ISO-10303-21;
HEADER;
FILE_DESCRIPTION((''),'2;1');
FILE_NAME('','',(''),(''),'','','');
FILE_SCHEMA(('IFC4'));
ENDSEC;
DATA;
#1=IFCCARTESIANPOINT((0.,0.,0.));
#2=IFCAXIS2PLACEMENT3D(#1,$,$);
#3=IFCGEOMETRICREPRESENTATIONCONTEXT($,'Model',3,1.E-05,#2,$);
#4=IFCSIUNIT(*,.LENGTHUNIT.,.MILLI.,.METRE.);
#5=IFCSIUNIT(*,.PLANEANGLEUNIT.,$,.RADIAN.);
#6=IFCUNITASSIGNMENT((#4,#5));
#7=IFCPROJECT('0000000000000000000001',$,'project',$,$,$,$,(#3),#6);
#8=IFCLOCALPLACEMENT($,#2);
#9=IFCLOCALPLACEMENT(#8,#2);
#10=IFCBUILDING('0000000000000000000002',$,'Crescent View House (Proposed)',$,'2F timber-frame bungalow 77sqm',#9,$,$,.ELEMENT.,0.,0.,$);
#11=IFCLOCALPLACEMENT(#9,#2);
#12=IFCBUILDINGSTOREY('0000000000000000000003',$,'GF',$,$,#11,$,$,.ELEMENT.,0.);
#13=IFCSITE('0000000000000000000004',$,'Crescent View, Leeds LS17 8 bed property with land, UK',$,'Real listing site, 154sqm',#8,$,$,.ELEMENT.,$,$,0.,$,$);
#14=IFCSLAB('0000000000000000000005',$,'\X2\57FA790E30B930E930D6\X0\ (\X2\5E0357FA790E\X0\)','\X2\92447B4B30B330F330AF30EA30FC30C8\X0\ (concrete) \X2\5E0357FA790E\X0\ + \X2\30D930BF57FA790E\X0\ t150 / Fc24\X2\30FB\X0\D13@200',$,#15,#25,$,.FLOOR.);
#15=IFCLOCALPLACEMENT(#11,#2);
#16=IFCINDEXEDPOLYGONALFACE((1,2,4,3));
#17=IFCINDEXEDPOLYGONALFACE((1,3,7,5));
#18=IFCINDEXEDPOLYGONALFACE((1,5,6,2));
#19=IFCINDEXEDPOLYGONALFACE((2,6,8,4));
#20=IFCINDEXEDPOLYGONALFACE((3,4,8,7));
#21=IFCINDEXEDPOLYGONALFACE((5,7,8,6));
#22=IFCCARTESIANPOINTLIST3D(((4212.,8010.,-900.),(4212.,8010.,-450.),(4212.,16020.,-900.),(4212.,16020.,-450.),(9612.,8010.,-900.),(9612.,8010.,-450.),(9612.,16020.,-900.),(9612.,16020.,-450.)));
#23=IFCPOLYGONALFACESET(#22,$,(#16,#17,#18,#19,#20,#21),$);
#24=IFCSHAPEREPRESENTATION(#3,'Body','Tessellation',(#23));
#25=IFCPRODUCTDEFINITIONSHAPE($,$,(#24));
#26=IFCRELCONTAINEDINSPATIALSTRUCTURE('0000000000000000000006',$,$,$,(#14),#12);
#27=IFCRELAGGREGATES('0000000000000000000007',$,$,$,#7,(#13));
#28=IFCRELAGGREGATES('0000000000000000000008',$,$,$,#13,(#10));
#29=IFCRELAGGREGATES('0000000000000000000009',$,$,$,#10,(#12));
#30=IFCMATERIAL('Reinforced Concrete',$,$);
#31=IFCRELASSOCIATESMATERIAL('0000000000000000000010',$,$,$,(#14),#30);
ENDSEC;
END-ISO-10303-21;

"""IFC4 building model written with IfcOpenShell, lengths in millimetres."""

from ifc_helpers import new_model, si_unit, frame, frame_2d, origin, place, context, project, spatial, rectangle, extrude, material, element, save


model = new_model("IFC4")

# Units and contexts
model_context = context("Model", 3, precision=1e-05, world=origin())
ifc_project = project(units=[si_unit("LENGTHUNIT", "METRE", prefix="MILLI"), si_unit("PLANEANGLEUNIT", "RADIAN")], contexts=[model_context])

# Site, building, storey
site_placement = place(None, origin())
site = spatial("IfcSite", under=ifc_project, at=site_placement, Name="Crescent View, Leeds LS17 8 bed property with land, UK", ObjectType="Real listing site, 154sqm", CompositionType="ELEMENT", RefElevation=0.0)
building_placement = place(site_placement, origin())
building = spatial("IfcBuilding", under=site, at=building_placement, Name="Crescent View House (Proposed)", ObjectType="2F timber-frame bungalow 77sqm", CompositionType="ELEMENT", ElevationOfRefHeight=0.0, ElevationOfTerrain=0.0)
storey_placement = place(building_placement, origin())
storey = spatial("IfcBuildingStorey", under=building, at=storey_placement, Name="GF", CompositionType="ELEMENT", Elevation=0.0)

# Slab
ifc_material_1 = material(Name="Reinforced Concrete")
slab_1_placement = place(storey_placement, frame((2106.0, 4005.0, -450.0)))
element("IfcSlab", 1, at=slab_1_placement, inside=storey, material=ifc_material_1, Name="基礎スラブ (布基礎)", Description="鉄筋コンクリート (concrete) 布基礎 + ベタ基礎 t150 / Fc24・D13@200", PredefinedType="FLOOR", context=model_context, shape_type="SweptSolid", body=[
    extrude(rectangle(XDim=5400.0, YDim=8010.0, at=frame_2d((2700.0, 4005.0))), frame((2106.0, 4005.0, -450.0)), (0.0, 0.0, 1.0), 450.0),
])

save(model, "model.ifc")
